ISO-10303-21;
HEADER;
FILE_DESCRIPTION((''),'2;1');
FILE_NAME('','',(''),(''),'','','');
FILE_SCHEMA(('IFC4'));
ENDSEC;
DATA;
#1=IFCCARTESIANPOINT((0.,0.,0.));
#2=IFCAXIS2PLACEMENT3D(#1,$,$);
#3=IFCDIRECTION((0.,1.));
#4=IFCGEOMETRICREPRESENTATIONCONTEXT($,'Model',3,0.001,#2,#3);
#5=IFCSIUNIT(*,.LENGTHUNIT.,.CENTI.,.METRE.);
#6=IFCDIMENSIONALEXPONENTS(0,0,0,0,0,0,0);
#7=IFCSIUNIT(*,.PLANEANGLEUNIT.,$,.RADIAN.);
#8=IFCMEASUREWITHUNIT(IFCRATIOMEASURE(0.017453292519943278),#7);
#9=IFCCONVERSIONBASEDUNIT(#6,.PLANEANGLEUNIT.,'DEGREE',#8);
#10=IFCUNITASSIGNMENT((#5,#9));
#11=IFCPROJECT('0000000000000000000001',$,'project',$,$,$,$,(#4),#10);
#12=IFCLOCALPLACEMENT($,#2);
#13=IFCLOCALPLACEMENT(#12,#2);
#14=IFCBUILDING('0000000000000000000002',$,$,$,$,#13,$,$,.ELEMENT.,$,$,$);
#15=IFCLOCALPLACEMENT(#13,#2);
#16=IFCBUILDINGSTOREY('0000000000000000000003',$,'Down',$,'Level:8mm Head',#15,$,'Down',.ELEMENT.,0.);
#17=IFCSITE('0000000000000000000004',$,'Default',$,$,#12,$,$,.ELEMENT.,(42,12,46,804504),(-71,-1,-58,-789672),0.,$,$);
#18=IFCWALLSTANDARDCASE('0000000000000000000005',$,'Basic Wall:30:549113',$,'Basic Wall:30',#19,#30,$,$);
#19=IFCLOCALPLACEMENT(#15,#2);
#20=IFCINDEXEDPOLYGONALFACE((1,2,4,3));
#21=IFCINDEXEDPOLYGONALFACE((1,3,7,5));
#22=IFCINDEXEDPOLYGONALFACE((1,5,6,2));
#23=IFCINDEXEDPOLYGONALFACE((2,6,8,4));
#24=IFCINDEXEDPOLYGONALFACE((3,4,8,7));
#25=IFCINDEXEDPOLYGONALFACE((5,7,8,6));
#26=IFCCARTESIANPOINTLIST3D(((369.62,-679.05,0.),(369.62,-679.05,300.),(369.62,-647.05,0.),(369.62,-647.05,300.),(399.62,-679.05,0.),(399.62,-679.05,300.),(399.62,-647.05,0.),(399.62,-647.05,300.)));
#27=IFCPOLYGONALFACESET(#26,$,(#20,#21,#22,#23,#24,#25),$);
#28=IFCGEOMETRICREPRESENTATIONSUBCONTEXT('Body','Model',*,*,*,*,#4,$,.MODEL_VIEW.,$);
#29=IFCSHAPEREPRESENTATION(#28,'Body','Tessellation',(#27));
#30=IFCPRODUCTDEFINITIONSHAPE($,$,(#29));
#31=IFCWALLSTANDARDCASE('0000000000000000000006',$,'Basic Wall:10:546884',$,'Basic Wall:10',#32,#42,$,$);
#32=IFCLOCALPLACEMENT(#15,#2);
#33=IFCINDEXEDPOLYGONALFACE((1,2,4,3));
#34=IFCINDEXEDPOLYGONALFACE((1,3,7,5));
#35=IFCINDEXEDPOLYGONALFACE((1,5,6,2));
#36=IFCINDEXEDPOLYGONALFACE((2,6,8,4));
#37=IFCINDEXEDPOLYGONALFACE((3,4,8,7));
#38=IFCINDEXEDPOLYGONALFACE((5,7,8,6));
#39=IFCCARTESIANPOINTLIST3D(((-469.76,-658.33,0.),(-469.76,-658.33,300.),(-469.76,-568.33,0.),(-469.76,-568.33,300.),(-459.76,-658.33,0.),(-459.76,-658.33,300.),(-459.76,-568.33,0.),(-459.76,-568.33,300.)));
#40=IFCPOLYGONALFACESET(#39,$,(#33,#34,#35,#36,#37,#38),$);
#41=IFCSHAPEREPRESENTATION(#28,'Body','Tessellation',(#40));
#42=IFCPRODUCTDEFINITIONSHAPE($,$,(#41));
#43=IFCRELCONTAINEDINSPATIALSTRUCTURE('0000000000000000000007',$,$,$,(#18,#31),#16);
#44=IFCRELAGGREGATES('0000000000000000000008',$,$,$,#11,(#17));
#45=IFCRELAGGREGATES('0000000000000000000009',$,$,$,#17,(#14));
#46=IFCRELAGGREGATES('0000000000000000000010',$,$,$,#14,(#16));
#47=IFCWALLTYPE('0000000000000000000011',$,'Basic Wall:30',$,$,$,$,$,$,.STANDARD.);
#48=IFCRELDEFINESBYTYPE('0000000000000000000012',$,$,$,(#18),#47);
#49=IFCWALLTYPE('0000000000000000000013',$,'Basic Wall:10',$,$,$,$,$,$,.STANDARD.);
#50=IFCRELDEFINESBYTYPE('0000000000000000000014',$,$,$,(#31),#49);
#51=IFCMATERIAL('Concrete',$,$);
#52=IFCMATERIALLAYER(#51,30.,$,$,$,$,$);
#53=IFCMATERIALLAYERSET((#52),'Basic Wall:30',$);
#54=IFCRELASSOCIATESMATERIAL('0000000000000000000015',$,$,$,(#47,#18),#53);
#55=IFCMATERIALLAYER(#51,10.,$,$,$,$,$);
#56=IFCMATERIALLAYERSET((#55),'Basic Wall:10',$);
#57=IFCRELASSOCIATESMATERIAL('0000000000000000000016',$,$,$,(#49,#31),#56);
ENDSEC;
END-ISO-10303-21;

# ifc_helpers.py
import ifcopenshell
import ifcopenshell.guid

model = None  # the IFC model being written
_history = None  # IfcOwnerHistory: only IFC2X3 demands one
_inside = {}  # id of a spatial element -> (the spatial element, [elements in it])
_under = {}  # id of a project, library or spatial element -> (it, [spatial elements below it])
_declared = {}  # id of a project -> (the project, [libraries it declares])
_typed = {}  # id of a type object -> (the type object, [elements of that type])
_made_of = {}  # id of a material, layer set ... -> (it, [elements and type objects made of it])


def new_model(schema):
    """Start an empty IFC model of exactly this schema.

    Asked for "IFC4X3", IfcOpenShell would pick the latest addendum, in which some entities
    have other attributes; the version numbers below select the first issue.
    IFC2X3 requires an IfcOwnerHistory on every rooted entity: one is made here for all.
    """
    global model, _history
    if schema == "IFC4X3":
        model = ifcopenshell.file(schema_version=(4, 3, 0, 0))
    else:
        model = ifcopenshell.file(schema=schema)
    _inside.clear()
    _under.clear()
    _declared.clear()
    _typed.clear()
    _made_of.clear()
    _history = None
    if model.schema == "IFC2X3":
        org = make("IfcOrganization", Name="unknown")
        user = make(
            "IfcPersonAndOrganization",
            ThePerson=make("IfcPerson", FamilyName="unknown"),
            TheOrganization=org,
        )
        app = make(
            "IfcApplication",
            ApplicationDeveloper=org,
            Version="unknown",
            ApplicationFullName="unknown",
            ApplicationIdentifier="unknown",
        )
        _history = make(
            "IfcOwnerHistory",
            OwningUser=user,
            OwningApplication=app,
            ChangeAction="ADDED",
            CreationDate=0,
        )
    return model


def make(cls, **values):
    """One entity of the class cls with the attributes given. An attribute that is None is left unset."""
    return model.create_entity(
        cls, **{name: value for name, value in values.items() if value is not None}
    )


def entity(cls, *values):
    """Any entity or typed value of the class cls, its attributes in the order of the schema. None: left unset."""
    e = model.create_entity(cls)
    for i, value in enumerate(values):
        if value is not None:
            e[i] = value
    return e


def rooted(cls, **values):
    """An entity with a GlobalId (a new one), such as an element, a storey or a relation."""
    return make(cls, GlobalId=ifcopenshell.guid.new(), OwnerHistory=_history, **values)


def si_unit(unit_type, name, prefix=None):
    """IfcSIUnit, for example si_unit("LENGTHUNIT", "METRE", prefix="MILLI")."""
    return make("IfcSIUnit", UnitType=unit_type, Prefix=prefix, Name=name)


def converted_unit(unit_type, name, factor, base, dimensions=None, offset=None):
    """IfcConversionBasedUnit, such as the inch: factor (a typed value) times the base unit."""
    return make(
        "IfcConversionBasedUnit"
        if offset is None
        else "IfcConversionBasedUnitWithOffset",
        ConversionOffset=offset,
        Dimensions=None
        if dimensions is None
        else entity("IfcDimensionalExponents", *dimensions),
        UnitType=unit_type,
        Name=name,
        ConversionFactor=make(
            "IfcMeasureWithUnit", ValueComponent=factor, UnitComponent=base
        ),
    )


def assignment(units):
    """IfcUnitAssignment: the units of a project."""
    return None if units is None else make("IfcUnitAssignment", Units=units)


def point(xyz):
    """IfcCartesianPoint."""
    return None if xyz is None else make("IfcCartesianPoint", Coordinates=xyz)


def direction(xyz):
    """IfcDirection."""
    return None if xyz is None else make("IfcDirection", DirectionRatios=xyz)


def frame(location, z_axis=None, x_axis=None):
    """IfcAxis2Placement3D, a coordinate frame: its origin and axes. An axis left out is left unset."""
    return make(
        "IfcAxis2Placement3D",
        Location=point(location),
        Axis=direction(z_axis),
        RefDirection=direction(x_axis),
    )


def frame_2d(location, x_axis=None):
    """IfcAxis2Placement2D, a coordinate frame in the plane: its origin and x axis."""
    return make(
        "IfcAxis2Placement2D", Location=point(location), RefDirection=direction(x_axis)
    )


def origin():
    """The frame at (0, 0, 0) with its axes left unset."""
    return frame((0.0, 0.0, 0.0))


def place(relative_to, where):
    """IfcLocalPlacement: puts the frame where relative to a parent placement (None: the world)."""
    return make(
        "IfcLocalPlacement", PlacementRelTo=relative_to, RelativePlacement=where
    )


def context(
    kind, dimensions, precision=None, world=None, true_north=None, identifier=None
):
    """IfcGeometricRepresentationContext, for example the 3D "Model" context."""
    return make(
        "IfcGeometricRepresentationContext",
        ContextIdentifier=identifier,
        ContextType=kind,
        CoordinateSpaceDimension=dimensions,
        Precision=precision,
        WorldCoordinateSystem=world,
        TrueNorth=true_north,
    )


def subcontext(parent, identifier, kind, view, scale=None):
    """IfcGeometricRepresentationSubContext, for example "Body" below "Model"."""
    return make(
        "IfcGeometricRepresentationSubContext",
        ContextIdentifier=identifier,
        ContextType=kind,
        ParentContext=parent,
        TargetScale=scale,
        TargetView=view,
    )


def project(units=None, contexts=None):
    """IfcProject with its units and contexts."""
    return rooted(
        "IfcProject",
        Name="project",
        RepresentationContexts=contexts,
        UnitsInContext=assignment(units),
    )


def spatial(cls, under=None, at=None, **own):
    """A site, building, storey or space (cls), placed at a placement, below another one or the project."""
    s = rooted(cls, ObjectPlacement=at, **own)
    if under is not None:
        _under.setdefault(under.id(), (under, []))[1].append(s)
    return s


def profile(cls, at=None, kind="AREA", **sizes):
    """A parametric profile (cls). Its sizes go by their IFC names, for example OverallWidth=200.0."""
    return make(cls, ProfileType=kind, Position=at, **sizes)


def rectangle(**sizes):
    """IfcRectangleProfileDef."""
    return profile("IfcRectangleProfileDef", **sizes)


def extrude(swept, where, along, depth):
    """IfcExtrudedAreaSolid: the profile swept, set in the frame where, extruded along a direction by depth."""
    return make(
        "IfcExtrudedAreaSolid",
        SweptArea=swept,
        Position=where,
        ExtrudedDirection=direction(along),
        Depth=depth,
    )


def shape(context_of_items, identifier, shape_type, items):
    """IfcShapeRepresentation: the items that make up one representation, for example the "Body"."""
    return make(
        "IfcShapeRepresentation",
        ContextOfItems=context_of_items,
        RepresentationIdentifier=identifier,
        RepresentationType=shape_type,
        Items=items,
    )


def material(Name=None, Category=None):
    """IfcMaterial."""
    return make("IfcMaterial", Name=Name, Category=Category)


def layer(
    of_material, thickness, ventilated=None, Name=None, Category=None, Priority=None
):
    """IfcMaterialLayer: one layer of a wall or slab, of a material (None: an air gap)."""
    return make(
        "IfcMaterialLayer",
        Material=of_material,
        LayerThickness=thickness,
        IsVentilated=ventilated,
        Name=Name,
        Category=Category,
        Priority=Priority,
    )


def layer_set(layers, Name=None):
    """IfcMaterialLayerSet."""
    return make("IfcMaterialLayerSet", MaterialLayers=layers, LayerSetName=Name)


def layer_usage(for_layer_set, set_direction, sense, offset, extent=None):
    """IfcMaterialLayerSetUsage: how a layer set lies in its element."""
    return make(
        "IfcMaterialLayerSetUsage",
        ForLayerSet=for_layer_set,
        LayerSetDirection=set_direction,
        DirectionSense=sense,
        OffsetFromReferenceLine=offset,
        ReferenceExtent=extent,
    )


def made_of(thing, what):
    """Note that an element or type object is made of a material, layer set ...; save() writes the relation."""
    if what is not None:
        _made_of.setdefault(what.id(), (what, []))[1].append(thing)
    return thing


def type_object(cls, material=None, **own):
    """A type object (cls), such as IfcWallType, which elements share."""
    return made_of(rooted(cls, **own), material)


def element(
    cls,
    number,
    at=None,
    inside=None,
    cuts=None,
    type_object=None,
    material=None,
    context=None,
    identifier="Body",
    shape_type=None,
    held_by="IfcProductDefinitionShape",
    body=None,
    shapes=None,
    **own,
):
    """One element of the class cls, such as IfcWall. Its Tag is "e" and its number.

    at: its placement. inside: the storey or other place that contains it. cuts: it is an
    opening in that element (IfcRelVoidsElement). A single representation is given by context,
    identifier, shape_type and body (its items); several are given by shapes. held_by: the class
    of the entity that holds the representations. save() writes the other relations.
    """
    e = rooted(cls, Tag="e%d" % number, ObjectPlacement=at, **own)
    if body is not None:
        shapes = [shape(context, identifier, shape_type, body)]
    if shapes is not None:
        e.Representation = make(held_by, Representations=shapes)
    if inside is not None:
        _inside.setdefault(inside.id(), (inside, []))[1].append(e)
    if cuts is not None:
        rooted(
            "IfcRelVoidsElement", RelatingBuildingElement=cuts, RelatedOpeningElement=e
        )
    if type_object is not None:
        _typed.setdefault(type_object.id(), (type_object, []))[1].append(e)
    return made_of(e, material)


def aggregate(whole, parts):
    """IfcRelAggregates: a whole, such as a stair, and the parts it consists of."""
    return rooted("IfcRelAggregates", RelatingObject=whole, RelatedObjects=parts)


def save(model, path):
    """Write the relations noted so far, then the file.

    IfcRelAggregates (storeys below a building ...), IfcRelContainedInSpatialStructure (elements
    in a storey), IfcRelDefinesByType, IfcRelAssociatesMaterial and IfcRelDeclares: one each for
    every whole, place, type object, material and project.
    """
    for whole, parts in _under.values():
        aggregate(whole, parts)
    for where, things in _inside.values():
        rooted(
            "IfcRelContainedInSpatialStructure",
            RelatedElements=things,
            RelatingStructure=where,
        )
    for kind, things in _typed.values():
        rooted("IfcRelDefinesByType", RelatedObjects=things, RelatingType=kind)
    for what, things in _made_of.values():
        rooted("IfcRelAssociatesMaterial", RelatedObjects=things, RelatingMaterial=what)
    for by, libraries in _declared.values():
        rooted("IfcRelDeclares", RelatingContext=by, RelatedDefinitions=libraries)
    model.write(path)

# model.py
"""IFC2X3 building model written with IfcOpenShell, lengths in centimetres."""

from ifc_helpers import new_model, entity, si_unit, converted_unit, direction, frame, frame_2d, origin, place, context, subcontext, project, spatial, rectangle, extrude, material, layer, layer_set, layer_usage, type_object, element, save


model = new_model("IFC2X3")

# Units and contexts
model_context = context("Model", 3, precision=0.001, world=origin(), true_north=direction((0.0, 1.0)))
body_context = subcontext(model_context, "Body", "Model", "MODEL_VIEW")
ifc_project = project(units=[si_unit("LENGTHUNIT", "METRE", prefix="CENTI"), converted_unit("PLANEANGLEUNIT", "DEGREE", entity("IfcRatioMeasure", 0.017453292519943278), si_unit("PLANEANGLEUNIT", "RADIAN"), dimensions=[0, 0, 0, 0, 0, 0, 0])], contexts=[model_context])

# Site, building, storey
site_placement = place(None, origin())
site = spatial("IfcSite", under=ifc_project, at=site_placement, Name="Default", CompositionType="ELEMENT", RefLatitude=(42, 12, 46, 804504), RefLongitude=(-71, -1, -58, -789672), RefElevation=0.0)
building_placement = place(site_placement, origin())
building = spatial("IfcBuilding", under=site, at=building_placement, CompositionType="ELEMENT")
storey_placement = place(building_placement, origin())
storey = spatial("IfcBuildingStorey", under=building, at=storey_placement, Name="Down", ObjectType="Level:8mm Head", LongName="Down", CompositionType="ELEMENT", Elevation=0.0)

# Shared definitions
ifc_material = material(Name="Concrete")

# Walls
ifc_layer_1 = layer(ifc_material, 30.0)
ifc_layer_set_1 = layer_set([ifc_layer_1], Name="Basic Wall:30")
wall_type_1 = type_object("IfcWallType", Name="Basic Wall:30", PredefinedType="STANDARD", material=ifc_layer_set_1)
ifc_layer_usage_1 = layer_usage(ifc_layer_set_1, "AXIS2", "NEGATIVE", 15.0)
wall_1_placement = place(storey_placement, frame((384.62, -647.05, 0.0), z_axis=(0.0, 0.0, 1.0), x_axis=(0.0, -1.0, 0.0)))
element("IfcWallStandardCase", 1, at=wall_1_placement, inside=storey, type_object=wall_type_1, material=ifc_layer_usage_1, Name="Basic Wall:30:549113", ObjectType="Basic Wall:30", context=body_context, shape_type="SweptSolid", body=[
    extrude(rectangle(XDim=32.0, YDim=30.0, at=frame_2d((16.0, 0.0), x_axis=(-1.0, 0.0))), origin(), (0.0, 0.0, 1.0), 300.0),
])
ifc_layer_2 = layer(ifc_material, 10.0)
ifc_layer_set_2 = layer_set([ifc_layer_2], Name="Basic Wall:10")
ifc_layer_usage_2 = layer_usage(ifc_layer_set_2, "AXIS2", "NEGATIVE", 5.0)
wall_type_2 = type_object("IfcWallType", Name="Basic Wall:10", PredefinedType="STANDARD", material=ifc_layer_set_2)
wall_2_placement = place(storey_placement, frame((-464.76, -568.33, 0.0), z_axis=(0.0, 0.0, 1.0), x_axis=(0.0, -1.0, 0.0)))
element("IfcWallStandardCase", 2, at=wall_2_placement, inside=storey, type_object=wall_type_2, material=ifc_layer_usage_2, Name="Basic Wall:10:546884", ObjectType="Basic Wall:10", context=body_context, shape_type="SweptSolid", body=[
    extrude(rectangle(XDim=90.0, YDim=10.0, at=frame_2d((45.0, 0.0), x_axis=(-1.0, 0.0))), origin(), (0.0, 0.0, 1.0), 300.0),
])

save(model, "model.ifc")
